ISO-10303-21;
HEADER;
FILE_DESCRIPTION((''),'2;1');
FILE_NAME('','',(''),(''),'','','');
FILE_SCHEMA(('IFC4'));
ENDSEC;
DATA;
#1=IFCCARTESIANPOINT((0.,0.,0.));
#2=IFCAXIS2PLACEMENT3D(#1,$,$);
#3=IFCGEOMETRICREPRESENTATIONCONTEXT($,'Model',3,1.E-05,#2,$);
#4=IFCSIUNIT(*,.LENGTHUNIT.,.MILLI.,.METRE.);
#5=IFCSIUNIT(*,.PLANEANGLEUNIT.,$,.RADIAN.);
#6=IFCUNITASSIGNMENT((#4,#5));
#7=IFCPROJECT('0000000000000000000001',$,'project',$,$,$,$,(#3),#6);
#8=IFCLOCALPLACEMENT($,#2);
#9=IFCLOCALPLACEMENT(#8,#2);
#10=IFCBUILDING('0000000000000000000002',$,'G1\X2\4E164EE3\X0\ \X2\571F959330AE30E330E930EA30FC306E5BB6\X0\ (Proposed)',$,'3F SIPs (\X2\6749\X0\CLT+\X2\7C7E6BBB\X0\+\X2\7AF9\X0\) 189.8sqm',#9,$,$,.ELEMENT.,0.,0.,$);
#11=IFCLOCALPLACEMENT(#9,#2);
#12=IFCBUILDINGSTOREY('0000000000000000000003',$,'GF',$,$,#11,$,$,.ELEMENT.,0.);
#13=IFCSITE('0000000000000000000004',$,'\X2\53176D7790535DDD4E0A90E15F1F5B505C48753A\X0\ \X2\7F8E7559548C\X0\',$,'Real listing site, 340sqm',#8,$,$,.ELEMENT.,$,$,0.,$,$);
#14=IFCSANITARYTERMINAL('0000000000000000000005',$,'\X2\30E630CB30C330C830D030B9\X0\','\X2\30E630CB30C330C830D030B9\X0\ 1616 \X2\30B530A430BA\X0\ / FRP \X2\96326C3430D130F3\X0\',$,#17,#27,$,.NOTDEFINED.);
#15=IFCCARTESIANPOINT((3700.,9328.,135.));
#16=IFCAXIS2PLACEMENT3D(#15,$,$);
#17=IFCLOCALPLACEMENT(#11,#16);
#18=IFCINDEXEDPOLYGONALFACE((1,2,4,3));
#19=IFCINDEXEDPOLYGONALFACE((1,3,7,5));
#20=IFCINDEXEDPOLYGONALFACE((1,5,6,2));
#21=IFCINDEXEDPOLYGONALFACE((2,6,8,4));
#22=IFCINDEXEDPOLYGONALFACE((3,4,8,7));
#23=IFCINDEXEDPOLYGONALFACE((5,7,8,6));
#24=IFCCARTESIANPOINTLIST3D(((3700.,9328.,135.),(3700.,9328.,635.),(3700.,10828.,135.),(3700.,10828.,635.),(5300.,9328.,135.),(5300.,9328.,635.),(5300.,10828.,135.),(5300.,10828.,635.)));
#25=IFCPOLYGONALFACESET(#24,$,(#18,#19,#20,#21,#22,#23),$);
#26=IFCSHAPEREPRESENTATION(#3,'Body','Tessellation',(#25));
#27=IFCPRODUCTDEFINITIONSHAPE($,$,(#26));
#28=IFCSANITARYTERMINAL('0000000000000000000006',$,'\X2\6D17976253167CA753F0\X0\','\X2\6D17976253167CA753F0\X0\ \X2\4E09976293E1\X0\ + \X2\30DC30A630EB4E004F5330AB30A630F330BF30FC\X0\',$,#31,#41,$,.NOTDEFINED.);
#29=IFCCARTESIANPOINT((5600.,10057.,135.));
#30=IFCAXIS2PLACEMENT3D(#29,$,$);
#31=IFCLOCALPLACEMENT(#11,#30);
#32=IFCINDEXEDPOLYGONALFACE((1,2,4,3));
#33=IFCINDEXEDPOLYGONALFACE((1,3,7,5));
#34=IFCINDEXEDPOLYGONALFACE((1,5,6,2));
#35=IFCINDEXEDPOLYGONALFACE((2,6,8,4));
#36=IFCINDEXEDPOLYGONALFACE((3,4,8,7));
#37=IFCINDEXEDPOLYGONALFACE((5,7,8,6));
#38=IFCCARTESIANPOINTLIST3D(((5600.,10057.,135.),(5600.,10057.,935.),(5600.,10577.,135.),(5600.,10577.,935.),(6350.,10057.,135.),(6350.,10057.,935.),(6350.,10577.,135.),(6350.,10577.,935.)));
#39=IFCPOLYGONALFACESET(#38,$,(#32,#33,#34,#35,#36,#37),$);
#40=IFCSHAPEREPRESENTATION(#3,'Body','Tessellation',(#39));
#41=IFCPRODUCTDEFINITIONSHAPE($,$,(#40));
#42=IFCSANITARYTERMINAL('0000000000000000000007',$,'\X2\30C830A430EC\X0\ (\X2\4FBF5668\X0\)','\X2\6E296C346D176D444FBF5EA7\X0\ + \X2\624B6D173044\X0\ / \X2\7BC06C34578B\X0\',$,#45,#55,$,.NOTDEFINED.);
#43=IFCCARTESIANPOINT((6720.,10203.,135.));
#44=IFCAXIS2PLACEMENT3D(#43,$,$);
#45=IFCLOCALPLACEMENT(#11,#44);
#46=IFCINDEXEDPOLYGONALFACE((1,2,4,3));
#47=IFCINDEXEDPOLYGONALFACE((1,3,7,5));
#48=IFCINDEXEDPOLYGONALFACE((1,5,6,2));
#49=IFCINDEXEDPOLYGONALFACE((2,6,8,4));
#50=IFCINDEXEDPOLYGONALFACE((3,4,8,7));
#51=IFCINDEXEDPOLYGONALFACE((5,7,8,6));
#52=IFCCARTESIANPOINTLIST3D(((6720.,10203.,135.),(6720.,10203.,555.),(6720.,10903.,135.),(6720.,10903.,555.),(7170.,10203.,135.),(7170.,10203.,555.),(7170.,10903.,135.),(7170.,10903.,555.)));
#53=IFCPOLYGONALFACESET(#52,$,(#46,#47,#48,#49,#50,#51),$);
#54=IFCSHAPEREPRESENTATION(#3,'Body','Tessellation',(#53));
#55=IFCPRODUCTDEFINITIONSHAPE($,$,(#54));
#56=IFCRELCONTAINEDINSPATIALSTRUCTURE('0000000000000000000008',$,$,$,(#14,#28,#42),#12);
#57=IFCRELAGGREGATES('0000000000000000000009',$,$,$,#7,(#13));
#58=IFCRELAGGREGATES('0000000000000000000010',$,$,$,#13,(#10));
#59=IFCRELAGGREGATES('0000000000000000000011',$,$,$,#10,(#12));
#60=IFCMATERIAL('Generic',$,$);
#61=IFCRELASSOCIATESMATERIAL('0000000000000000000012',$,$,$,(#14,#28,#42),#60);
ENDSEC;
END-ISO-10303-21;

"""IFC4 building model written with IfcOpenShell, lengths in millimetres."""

from ifc_helpers import new_model, si_unit, frame, frame_2d, origin, place, context, project, spatial, rectangle, extrude, material, element, save


model = new_model("IFC4")

# Units and contexts
model_context = context("Model", 3, precision=1e-05, world=origin())
ifc_project = project(units=[si_unit("LENGTHUNIT", "METRE", prefix="MILLI"), si_unit("PLANEANGLEUNIT", "RADIAN")], contexts=[model_context])

# Site, building, storey
site_placement = place(None, origin())
site = spatial("IfcSite", under=ifc_project, at=site_placement, Name="北海道川上郡弟子屈町 美留和", ObjectType="Real listing site, 340sqm", CompositionType="ELEMENT", RefElevation=0.0)
building_placement = place(site_placement, origin())
building = spatial("IfcBuilding", under=site, at=building_placement, Name="G1世代 土間ギャラリーの家 (Proposed)", ObjectType="3F SIPs (杉CLT+籾殻+竹) 189.8sqm", CompositionType="ELEMENT", ElevationOfRefHeight=0.0, ElevationOfTerrain=0.0)
storey_placement = place(building_placement, origin())
storey = spatial("IfcBuildingStorey", under=building, at=storey_placement, Name="GF", CompositionType="ELEMENT", Elevation=0.0)

# Shared definitions
ifc_material_1 = material(Name="Generic")

# Sanitary terminals
sanitary_terminal_1_placement = place(storey_placement, frame((3700.0, 9328.0, 135.0)))
element("IfcSanitaryTerminal", 1, at=sanitary_terminal_1_placement, inside=storey, material=ifc_material_1, Name="ユニットバス", Description="ユニットバス 1616 サイズ / FRP 防水パン", PredefinedType="NOTDEFINED", context=model_context, shape_type="SweptSolid", body=[
    extrude(rectangle(XDim=1600.0, YDim=1500.0, at=frame_2d((800.0, 750.0))), frame((3700.0, 9328.0, 135.0)), (0.0, 0.0, 1.0), 500.0),
])
sanitary_terminal_2_placement = place(storey_placement, frame((5600.0, 10057.0, 135.0)))
element("IfcSanitaryTerminal", 2, at=sanitary_terminal_2_placement, inside=storey, material=ifc_material_1, Name="洗面化粧台", Description="洗面化粧台 三面鏡 + ボウル一体カウンター", PredefinedType="NOTDEFINED", context=model_context, shape_type="SweptSolid", body=[
    extrude(rectangle(XDim=750.0, YDim=520.0, at=frame_2d((375.0, 260.0))), frame((5600.0, 10057.0, 135.0)), (0.0, 0.0, 1.0), 800.0),
])
sanitary_terminal_3_placement = place(storey_placement, frame((6720.0, 10203.0, 135.0)))
element("IfcSanitaryTerminal", 3, at=sanitary_terminal_3_placement, inside=storey, material=ifc_material_1, Name="トイレ (便器)", Description="温水洗浄便座 + 手洗い / 節水型", PredefinedType="NOTDEFINED", context=model_context, shape_type="SweptSolid", body=[
    extrude(rectangle(XDim=450.0, YDim=700.0, at=frame_2d((225.0, 350.0))), frame((6720.0, 10203.0, 135.0)), (0.0, 0.0, 1.0), 420.0),
])

save(model, "model.ifc")
